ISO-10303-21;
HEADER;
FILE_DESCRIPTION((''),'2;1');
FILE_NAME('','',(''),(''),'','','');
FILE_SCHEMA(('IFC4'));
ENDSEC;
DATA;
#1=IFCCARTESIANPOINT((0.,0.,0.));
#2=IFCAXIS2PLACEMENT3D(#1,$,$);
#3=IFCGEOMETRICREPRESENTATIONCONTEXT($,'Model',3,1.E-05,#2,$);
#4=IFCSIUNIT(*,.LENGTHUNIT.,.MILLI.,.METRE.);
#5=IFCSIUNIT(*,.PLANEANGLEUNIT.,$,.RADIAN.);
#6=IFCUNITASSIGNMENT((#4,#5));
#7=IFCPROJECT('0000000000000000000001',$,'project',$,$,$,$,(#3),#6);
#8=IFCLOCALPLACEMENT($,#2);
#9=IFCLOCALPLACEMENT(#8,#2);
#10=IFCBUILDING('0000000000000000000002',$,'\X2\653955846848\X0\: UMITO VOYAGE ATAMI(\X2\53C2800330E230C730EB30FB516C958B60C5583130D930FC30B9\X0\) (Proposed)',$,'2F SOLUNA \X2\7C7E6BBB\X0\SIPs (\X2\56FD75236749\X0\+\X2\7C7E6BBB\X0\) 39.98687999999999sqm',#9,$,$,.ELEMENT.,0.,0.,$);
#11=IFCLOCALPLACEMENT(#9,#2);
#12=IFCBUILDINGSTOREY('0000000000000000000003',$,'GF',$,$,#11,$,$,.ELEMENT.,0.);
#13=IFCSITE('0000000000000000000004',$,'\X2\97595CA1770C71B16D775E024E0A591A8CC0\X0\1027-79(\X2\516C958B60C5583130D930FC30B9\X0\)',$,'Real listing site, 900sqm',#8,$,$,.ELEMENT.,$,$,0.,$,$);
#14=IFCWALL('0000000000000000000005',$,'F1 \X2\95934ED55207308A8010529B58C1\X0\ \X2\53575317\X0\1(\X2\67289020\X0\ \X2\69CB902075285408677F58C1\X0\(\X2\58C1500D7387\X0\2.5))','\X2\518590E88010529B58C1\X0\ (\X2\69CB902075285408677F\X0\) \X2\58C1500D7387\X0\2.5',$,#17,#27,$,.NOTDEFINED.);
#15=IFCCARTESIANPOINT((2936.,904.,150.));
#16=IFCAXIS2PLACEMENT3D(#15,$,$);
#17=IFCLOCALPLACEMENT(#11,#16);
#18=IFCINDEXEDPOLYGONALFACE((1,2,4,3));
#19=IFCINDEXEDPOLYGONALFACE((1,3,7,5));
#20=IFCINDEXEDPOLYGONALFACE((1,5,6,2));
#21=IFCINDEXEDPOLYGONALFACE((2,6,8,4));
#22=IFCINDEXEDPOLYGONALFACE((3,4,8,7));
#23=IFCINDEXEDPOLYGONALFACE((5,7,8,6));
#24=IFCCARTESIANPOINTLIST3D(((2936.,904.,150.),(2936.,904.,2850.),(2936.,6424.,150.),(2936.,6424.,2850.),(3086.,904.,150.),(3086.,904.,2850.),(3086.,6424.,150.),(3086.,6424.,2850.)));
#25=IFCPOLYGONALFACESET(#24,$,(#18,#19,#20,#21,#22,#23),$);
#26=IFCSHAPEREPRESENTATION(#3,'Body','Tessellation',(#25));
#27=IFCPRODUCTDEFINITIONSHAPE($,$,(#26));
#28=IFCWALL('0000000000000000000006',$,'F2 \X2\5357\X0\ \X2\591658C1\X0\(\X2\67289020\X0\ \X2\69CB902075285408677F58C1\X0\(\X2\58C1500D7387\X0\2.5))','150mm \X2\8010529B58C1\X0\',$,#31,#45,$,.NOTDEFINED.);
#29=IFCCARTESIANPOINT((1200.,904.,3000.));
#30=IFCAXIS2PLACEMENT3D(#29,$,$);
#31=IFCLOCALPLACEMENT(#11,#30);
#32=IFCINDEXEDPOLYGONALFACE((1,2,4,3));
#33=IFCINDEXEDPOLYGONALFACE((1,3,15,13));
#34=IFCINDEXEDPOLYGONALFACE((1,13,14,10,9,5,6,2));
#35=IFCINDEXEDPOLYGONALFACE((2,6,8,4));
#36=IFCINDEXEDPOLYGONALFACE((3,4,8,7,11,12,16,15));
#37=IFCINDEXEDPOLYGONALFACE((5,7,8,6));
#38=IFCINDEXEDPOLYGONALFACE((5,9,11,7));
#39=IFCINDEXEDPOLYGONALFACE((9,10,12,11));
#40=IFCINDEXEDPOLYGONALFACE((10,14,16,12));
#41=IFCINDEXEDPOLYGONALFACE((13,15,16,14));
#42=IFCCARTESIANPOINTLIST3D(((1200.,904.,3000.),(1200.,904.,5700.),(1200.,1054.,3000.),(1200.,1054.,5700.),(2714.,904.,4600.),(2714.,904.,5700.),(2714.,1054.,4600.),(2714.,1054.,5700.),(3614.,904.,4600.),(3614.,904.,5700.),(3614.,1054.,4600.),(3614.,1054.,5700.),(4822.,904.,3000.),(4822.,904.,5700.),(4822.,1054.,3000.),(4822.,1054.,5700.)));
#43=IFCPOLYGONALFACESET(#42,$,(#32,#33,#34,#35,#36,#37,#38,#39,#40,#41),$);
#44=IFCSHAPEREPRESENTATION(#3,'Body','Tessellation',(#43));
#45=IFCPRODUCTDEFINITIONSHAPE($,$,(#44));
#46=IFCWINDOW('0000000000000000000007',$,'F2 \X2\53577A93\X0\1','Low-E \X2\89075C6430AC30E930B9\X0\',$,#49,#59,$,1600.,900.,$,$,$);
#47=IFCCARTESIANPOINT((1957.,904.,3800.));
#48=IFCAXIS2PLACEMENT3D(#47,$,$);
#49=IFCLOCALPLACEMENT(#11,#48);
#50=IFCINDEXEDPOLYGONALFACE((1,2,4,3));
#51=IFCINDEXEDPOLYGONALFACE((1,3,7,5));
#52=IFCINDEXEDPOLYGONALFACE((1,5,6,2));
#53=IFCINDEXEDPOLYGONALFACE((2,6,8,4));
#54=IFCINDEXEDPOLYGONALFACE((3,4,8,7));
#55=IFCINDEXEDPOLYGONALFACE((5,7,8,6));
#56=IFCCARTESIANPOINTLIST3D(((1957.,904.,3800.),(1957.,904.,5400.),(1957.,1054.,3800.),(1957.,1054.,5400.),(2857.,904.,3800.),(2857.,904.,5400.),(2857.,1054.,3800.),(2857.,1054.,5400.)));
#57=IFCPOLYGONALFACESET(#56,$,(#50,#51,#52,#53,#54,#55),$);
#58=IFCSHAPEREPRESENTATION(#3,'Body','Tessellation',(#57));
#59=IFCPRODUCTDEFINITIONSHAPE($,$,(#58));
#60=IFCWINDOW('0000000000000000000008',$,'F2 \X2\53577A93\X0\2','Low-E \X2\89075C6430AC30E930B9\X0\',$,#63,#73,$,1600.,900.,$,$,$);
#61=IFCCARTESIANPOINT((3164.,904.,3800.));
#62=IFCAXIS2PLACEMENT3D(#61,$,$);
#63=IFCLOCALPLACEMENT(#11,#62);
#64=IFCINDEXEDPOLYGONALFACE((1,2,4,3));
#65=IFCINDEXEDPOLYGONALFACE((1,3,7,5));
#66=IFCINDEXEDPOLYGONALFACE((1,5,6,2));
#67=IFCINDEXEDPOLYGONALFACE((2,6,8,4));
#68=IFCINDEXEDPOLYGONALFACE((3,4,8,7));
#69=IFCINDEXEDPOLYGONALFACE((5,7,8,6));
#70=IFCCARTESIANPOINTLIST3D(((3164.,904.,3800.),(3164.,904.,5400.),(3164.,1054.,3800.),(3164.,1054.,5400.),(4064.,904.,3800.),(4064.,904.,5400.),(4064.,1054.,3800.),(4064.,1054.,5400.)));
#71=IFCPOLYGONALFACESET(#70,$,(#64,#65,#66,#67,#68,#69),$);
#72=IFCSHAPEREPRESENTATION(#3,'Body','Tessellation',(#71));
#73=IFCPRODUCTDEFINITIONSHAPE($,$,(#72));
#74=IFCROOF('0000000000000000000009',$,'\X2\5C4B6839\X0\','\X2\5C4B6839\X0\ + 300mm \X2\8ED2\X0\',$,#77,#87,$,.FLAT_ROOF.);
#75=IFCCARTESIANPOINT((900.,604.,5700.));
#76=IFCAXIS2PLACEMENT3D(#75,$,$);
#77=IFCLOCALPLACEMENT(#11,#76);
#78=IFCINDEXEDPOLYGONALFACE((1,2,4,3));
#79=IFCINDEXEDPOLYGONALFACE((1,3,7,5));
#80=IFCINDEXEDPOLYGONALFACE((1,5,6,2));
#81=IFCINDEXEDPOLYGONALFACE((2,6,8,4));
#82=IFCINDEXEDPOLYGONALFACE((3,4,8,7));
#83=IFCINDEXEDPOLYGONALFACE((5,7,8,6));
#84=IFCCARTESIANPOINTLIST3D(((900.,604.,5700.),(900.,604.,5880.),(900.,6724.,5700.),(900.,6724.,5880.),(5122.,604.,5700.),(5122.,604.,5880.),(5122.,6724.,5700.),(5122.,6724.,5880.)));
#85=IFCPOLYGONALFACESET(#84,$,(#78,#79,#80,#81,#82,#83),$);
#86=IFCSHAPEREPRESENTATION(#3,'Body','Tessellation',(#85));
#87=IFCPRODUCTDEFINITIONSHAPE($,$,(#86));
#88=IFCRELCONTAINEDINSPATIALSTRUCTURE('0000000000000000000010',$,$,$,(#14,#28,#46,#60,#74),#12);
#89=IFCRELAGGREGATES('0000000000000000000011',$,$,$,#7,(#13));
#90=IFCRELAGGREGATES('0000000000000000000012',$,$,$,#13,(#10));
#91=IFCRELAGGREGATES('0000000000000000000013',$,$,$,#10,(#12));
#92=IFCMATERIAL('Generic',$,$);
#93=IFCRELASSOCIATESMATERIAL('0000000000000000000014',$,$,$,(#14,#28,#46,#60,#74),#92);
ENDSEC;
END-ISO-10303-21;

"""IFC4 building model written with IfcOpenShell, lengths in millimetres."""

from ifc_helpers import new_model, si_unit, frame, frame_2d, origin, place, context, project, spatial, rectangle, extrude, material, element, fill, save


model = new_model("IFC4")

# Units and contexts
model_context = context("Model", 3, precision=1e-05, world=origin())
ifc_project = project(units=[si_unit("LENGTHUNIT", "METRE", prefix="MILLI"), si_unit("PLANEANGLEUNIT", "RADIAN")], contexts=[model_context])

# Site, building, storey
site_placement = place(None, origin())
site = spatial("IfcSite", under=ifc_project, at=site_placement, Name="静岡県熱海市上多賀1027-79(公開情報ベース)", ObjectType="Real listing site, 900sqm", CompositionType="ELEMENT", RefElevation=0.0)
building_placement = place(site_placement, origin())
building = spatial("IfcBuilding", under=site, at=building_placement, Name="改善案: UMITO VOYAGE ATAMI(参考モデル・公開情報ベース) (Proposed)", ObjectType="2F SOLUNA 籾殻SIPs (国産杉+籾殻) 39.98687999999999sqm", CompositionType="ELEMENT", ElevationOfRefHeight=0.0, ElevationOfTerrain=0.0)
storey_placement = place(building_placement, origin())
storey = spatial("IfcBuildingStorey", under=building, at=storey_placement, Name="GF", CompositionType="ELEMENT", Elevation=0.0)

# Shared definitions
ifc_material_1 = material(Name="Generic")

# Wall
wall_1_placement = place(storey_placement, frame((2936.0, 904.0, 150.0)))
element("IfcWall", 1, at=wall_1_placement, inside=storey, material=ifc_material_1, Name="F1 間仕切り耐力壁 南北1(木造 構造用合板壁(壁倍率2.5))", Description="内部耐力壁 (構造用合板) 壁倍率2.5", PredefinedType="NOTDEFINED", context=model_context, shape_type="SweptSolid", body=[
    extrude(rectangle(XDim=150.0, YDim=5520.0, at=frame_2d((75.0, 2760.0))), frame((2936.0, 904.0, 150.0)), (0.0, 0.0, 1.0), 2700.0),
])

# Wall, openings, windows
wall_2_placement = place(storey_placement, frame((1200.0, 904.0, 3000.0)))
wall_2 = element("IfcWall", 2, at=wall_2_placement, inside=storey, material=ifc_material_1, Name="F2 南 外壁(木造 構造用合板壁(壁倍率2.5))", Description="150mm 耐力壁", PredefinedType="NOTDEFINED", context=model_context, shape_type="SweptSolid", body=[
    extrude(rectangle(XDim=3622.0, YDim=150.0, at=frame_2d((1811.0, 75.0))), frame((1200.0, 904.0, 3000.0)), (0.0, 0.0, 1.0), 2700.0),
])
opening_1_placement = place(storey_placement, frame((1957.0, 904.0, 3800.0)))
opening_1 = element("IfcOpeningElement", 3, at=opening_1_placement, cuts=wall_2, PredefinedType="NOTDEFINED", context=model_context, shape_type="SweptSolid", body=[
    extrude(rectangle(XDim=900.0, YDim=150.0, at=frame_2d((450.0, 75.0))), frame((1957.0, 904.0, 3800.0)), (0.0, 0.0, 1.0), 1600.0),
])
opening_2_placement = place(storey_placement, frame((3164.0, 904.0, 3800.0)))
opening_2 = element("IfcOpeningElement", 4, at=opening_2_placement, cuts=wall_2, PredefinedType="NOTDEFINED", context=model_context, shape_type="SweptSolid", body=[
    extrude(rectangle(XDim=900.0, YDim=150.0, at=frame_2d((450.0, 75.0))), frame((3164.0, 904.0, 3800.0)), (0.0, 0.0, 1.0), 1600.0),
])
window_1_placement = place(storey_placement, frame((1957.0, 904.0, 3800.0)))
window_1 = element("IfcWindow", 5, at=window_1_placement, inside=storey, material=ifc_material_1, Name="F2 南窓1", Description="Low-E 複層ガラス", OverallHeight=1600.0, OverallWidth=900.0, context=model_context, shape_type="SweptSolid", body=[
    extrude(rectangle(XDim=900.0, YDim=150.0, at=frame_2d((450.0, 75.0))), frame((1957.0, 904.0, 3800.0)), (0.0, 0.0, 1.0), 1600.0),
])
fill(opening_1, window_1)
window_2_placement = place(storey_placement, frame((3164.0, 904.0, 3800.0)))
window_2 = element("IfcWindow", 6, at=window_2_placement, inside=storey, material=ifc_material_1, Name="F2 南窓2", Description="Low-E 複層ガラス", OverallHeight=1600.0, OverallWidth=900.0, context=model_context, shape_type="SweptSolid", body=[
    extrude(rectangle(XDim=900.0, YDim=150.0, at=frame_2d((450.0, 75.0))), frame((3164.0, 904.0, 3800.0)), (0.0, 0.0, 1.0), 1600.0),
])
fill(opening_2, window_2)

# Roof
roof_placement = place(storey_placement, frame((900.0, 604.0, 5700.0)))
element("IfcRoof", 7, at=roof_placement, inside=storey, material=ifc_material_1, Name="屋根", Description="屋根 + 300mm 軒", PredefinedType="FLAT_ROOF", context=model_context, shape_type="SweptSolid", body=[
    extrude(rectangle(XDim=4222.0, YDim=6120.0, at=frame_2d((2111.0, 3060.0))), frame((900.0, 604.0, 5700.0)), (0.0, 0.0, 1.0), 180.0),
])

save(model, "model.ifc")
